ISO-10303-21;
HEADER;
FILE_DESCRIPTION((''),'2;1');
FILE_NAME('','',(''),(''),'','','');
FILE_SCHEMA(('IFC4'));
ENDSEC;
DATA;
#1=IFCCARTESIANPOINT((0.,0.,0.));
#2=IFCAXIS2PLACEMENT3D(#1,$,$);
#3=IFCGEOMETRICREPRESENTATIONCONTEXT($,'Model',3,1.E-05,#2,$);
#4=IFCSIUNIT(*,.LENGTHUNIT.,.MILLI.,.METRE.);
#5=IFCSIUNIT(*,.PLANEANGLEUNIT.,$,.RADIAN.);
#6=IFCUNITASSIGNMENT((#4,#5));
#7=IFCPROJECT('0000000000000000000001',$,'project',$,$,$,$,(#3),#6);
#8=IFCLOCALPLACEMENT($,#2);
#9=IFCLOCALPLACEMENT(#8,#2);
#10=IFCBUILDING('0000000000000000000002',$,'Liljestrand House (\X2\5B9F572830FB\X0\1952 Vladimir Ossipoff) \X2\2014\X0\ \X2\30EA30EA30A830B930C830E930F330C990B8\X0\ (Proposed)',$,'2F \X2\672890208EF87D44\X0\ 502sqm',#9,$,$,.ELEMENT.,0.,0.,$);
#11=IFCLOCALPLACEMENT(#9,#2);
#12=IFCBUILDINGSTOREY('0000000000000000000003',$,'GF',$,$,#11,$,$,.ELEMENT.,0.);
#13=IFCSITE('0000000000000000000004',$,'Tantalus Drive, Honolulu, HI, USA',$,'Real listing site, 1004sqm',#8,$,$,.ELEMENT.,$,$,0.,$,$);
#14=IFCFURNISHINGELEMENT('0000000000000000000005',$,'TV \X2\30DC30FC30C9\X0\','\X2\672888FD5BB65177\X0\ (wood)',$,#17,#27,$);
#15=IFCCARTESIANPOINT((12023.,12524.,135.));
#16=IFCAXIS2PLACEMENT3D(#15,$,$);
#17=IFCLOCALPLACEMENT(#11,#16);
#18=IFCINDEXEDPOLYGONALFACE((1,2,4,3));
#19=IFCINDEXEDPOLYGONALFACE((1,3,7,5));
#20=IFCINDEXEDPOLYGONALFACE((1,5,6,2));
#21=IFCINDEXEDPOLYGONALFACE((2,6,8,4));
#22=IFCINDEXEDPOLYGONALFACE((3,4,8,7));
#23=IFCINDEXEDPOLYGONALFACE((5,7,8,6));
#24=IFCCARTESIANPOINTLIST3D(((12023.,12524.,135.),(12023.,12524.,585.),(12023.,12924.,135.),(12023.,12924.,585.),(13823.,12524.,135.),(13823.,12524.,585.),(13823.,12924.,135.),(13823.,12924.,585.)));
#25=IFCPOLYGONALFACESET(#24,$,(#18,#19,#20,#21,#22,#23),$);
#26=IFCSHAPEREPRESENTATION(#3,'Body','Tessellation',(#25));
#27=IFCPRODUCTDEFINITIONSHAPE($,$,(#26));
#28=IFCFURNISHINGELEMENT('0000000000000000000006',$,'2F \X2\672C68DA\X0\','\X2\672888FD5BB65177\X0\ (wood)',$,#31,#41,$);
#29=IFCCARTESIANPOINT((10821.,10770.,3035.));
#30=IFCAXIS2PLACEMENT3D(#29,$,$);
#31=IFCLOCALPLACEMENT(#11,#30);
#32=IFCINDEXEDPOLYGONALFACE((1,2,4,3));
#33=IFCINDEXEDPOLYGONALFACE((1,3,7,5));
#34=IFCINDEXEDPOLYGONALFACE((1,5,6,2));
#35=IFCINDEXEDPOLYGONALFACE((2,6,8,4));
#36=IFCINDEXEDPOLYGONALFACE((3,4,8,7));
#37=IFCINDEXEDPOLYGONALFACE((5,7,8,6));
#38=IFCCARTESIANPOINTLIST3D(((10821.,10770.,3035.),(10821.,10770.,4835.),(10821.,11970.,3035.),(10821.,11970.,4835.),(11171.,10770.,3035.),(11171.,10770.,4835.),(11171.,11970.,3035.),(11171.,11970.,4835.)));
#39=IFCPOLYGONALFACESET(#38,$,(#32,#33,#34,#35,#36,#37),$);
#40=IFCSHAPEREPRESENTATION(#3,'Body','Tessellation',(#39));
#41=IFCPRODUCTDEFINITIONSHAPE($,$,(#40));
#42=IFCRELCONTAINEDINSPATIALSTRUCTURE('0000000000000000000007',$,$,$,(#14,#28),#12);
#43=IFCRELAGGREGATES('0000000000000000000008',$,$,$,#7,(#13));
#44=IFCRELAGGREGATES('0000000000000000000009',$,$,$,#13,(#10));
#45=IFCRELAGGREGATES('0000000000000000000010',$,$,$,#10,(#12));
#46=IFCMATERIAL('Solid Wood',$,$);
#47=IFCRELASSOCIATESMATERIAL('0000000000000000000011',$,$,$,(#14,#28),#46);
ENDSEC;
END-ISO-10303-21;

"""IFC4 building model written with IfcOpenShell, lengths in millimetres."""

from ifc_helpers import new_model, si_unit, frame, frame_2d, origin, place, context, project, spatial, rectangle, extrude, material, element, save


model = new_model("IFC4")

# Units and contexts
model_context = context("Model", 3, precision=1e-05, world=origin())
ifc_project = project(units=[si_unit("LENGTHUNIT", "METRE", prefix="MILLI"), si_unit("PLANEANGLEUNIT", "RADIAN")], contexts=[model_context])

# Site, building, storey
site_placement = place(None, origin())
site = spatial("IfcSite", under=ifc_project, at=site_placement, Name="Tantalus Drive, Honolulu, HI, USA", ObjectType="Real listing site, 1004sqm", CompositionType="ELEMENT", RefElevation=0.0)
building_placement = place(site_placement, origin())
building = spatial("IfcBuilding", under=site, at=building_placement, Name="Liljestrand House (実在・1952 Vladimir Ossipoff) — リリエストランド邸 (Proposed)", ObjectType="2F 木造軸組 502sqm", CompositionType="ELEMENT", ElevationOfRefHeight=0.0, ElevationOfTerrain=0.0)
storey_placement = place(building_placement, origin())
storey = spatial("IfcBuildingStorey", under=building, at=storey_placement, Name="GF", CompositionType="ELEMENT", Elevation=0.0)

# Shared definitions
ifc_material_1 = material(Name="Solid Wood")

# Furnishing elements
furnishing_1_placement = place(storey_placement, frame((12023.0, 12524.0, 135.0)))
element("IfcFurnishingElement", 1, at=furnishing_1_placement, inside=storey, material=ifc_material_1, Name="TV ボード", Description="木製家具 (wood)", context=model_context, shape_type="SweptSolid", body=[
    extrude(rectangle(XDim=1800.0, YDim=400.0, at=frame_2d((900.0, 200.0))), frame((12023.0, 12524.0, 135.0)), (0.0, 0.0, 1.0), 450.0),
])
furnishing_2_placement = place(storey_placement, frame((10821.0, 10770.0, 3035.0)))
element("IfcFurnishingElement", 2, at=furnishing_2_placement, inside=storey, material=ifc_material_1, Name="2F 本棚", Description="木製家具 (wood)", context=model_context, shape_type="SweptSolid", body=[
    extrude(rectangle(XDim=350.0, YDim=1200.0, at=frame_2d((175.0, 600.0))), frame((10821.0, 10770.0, 3035.0)), (0.0, 0.0, 1.0), 1800.0),
])

save(model, "model.ifc")
